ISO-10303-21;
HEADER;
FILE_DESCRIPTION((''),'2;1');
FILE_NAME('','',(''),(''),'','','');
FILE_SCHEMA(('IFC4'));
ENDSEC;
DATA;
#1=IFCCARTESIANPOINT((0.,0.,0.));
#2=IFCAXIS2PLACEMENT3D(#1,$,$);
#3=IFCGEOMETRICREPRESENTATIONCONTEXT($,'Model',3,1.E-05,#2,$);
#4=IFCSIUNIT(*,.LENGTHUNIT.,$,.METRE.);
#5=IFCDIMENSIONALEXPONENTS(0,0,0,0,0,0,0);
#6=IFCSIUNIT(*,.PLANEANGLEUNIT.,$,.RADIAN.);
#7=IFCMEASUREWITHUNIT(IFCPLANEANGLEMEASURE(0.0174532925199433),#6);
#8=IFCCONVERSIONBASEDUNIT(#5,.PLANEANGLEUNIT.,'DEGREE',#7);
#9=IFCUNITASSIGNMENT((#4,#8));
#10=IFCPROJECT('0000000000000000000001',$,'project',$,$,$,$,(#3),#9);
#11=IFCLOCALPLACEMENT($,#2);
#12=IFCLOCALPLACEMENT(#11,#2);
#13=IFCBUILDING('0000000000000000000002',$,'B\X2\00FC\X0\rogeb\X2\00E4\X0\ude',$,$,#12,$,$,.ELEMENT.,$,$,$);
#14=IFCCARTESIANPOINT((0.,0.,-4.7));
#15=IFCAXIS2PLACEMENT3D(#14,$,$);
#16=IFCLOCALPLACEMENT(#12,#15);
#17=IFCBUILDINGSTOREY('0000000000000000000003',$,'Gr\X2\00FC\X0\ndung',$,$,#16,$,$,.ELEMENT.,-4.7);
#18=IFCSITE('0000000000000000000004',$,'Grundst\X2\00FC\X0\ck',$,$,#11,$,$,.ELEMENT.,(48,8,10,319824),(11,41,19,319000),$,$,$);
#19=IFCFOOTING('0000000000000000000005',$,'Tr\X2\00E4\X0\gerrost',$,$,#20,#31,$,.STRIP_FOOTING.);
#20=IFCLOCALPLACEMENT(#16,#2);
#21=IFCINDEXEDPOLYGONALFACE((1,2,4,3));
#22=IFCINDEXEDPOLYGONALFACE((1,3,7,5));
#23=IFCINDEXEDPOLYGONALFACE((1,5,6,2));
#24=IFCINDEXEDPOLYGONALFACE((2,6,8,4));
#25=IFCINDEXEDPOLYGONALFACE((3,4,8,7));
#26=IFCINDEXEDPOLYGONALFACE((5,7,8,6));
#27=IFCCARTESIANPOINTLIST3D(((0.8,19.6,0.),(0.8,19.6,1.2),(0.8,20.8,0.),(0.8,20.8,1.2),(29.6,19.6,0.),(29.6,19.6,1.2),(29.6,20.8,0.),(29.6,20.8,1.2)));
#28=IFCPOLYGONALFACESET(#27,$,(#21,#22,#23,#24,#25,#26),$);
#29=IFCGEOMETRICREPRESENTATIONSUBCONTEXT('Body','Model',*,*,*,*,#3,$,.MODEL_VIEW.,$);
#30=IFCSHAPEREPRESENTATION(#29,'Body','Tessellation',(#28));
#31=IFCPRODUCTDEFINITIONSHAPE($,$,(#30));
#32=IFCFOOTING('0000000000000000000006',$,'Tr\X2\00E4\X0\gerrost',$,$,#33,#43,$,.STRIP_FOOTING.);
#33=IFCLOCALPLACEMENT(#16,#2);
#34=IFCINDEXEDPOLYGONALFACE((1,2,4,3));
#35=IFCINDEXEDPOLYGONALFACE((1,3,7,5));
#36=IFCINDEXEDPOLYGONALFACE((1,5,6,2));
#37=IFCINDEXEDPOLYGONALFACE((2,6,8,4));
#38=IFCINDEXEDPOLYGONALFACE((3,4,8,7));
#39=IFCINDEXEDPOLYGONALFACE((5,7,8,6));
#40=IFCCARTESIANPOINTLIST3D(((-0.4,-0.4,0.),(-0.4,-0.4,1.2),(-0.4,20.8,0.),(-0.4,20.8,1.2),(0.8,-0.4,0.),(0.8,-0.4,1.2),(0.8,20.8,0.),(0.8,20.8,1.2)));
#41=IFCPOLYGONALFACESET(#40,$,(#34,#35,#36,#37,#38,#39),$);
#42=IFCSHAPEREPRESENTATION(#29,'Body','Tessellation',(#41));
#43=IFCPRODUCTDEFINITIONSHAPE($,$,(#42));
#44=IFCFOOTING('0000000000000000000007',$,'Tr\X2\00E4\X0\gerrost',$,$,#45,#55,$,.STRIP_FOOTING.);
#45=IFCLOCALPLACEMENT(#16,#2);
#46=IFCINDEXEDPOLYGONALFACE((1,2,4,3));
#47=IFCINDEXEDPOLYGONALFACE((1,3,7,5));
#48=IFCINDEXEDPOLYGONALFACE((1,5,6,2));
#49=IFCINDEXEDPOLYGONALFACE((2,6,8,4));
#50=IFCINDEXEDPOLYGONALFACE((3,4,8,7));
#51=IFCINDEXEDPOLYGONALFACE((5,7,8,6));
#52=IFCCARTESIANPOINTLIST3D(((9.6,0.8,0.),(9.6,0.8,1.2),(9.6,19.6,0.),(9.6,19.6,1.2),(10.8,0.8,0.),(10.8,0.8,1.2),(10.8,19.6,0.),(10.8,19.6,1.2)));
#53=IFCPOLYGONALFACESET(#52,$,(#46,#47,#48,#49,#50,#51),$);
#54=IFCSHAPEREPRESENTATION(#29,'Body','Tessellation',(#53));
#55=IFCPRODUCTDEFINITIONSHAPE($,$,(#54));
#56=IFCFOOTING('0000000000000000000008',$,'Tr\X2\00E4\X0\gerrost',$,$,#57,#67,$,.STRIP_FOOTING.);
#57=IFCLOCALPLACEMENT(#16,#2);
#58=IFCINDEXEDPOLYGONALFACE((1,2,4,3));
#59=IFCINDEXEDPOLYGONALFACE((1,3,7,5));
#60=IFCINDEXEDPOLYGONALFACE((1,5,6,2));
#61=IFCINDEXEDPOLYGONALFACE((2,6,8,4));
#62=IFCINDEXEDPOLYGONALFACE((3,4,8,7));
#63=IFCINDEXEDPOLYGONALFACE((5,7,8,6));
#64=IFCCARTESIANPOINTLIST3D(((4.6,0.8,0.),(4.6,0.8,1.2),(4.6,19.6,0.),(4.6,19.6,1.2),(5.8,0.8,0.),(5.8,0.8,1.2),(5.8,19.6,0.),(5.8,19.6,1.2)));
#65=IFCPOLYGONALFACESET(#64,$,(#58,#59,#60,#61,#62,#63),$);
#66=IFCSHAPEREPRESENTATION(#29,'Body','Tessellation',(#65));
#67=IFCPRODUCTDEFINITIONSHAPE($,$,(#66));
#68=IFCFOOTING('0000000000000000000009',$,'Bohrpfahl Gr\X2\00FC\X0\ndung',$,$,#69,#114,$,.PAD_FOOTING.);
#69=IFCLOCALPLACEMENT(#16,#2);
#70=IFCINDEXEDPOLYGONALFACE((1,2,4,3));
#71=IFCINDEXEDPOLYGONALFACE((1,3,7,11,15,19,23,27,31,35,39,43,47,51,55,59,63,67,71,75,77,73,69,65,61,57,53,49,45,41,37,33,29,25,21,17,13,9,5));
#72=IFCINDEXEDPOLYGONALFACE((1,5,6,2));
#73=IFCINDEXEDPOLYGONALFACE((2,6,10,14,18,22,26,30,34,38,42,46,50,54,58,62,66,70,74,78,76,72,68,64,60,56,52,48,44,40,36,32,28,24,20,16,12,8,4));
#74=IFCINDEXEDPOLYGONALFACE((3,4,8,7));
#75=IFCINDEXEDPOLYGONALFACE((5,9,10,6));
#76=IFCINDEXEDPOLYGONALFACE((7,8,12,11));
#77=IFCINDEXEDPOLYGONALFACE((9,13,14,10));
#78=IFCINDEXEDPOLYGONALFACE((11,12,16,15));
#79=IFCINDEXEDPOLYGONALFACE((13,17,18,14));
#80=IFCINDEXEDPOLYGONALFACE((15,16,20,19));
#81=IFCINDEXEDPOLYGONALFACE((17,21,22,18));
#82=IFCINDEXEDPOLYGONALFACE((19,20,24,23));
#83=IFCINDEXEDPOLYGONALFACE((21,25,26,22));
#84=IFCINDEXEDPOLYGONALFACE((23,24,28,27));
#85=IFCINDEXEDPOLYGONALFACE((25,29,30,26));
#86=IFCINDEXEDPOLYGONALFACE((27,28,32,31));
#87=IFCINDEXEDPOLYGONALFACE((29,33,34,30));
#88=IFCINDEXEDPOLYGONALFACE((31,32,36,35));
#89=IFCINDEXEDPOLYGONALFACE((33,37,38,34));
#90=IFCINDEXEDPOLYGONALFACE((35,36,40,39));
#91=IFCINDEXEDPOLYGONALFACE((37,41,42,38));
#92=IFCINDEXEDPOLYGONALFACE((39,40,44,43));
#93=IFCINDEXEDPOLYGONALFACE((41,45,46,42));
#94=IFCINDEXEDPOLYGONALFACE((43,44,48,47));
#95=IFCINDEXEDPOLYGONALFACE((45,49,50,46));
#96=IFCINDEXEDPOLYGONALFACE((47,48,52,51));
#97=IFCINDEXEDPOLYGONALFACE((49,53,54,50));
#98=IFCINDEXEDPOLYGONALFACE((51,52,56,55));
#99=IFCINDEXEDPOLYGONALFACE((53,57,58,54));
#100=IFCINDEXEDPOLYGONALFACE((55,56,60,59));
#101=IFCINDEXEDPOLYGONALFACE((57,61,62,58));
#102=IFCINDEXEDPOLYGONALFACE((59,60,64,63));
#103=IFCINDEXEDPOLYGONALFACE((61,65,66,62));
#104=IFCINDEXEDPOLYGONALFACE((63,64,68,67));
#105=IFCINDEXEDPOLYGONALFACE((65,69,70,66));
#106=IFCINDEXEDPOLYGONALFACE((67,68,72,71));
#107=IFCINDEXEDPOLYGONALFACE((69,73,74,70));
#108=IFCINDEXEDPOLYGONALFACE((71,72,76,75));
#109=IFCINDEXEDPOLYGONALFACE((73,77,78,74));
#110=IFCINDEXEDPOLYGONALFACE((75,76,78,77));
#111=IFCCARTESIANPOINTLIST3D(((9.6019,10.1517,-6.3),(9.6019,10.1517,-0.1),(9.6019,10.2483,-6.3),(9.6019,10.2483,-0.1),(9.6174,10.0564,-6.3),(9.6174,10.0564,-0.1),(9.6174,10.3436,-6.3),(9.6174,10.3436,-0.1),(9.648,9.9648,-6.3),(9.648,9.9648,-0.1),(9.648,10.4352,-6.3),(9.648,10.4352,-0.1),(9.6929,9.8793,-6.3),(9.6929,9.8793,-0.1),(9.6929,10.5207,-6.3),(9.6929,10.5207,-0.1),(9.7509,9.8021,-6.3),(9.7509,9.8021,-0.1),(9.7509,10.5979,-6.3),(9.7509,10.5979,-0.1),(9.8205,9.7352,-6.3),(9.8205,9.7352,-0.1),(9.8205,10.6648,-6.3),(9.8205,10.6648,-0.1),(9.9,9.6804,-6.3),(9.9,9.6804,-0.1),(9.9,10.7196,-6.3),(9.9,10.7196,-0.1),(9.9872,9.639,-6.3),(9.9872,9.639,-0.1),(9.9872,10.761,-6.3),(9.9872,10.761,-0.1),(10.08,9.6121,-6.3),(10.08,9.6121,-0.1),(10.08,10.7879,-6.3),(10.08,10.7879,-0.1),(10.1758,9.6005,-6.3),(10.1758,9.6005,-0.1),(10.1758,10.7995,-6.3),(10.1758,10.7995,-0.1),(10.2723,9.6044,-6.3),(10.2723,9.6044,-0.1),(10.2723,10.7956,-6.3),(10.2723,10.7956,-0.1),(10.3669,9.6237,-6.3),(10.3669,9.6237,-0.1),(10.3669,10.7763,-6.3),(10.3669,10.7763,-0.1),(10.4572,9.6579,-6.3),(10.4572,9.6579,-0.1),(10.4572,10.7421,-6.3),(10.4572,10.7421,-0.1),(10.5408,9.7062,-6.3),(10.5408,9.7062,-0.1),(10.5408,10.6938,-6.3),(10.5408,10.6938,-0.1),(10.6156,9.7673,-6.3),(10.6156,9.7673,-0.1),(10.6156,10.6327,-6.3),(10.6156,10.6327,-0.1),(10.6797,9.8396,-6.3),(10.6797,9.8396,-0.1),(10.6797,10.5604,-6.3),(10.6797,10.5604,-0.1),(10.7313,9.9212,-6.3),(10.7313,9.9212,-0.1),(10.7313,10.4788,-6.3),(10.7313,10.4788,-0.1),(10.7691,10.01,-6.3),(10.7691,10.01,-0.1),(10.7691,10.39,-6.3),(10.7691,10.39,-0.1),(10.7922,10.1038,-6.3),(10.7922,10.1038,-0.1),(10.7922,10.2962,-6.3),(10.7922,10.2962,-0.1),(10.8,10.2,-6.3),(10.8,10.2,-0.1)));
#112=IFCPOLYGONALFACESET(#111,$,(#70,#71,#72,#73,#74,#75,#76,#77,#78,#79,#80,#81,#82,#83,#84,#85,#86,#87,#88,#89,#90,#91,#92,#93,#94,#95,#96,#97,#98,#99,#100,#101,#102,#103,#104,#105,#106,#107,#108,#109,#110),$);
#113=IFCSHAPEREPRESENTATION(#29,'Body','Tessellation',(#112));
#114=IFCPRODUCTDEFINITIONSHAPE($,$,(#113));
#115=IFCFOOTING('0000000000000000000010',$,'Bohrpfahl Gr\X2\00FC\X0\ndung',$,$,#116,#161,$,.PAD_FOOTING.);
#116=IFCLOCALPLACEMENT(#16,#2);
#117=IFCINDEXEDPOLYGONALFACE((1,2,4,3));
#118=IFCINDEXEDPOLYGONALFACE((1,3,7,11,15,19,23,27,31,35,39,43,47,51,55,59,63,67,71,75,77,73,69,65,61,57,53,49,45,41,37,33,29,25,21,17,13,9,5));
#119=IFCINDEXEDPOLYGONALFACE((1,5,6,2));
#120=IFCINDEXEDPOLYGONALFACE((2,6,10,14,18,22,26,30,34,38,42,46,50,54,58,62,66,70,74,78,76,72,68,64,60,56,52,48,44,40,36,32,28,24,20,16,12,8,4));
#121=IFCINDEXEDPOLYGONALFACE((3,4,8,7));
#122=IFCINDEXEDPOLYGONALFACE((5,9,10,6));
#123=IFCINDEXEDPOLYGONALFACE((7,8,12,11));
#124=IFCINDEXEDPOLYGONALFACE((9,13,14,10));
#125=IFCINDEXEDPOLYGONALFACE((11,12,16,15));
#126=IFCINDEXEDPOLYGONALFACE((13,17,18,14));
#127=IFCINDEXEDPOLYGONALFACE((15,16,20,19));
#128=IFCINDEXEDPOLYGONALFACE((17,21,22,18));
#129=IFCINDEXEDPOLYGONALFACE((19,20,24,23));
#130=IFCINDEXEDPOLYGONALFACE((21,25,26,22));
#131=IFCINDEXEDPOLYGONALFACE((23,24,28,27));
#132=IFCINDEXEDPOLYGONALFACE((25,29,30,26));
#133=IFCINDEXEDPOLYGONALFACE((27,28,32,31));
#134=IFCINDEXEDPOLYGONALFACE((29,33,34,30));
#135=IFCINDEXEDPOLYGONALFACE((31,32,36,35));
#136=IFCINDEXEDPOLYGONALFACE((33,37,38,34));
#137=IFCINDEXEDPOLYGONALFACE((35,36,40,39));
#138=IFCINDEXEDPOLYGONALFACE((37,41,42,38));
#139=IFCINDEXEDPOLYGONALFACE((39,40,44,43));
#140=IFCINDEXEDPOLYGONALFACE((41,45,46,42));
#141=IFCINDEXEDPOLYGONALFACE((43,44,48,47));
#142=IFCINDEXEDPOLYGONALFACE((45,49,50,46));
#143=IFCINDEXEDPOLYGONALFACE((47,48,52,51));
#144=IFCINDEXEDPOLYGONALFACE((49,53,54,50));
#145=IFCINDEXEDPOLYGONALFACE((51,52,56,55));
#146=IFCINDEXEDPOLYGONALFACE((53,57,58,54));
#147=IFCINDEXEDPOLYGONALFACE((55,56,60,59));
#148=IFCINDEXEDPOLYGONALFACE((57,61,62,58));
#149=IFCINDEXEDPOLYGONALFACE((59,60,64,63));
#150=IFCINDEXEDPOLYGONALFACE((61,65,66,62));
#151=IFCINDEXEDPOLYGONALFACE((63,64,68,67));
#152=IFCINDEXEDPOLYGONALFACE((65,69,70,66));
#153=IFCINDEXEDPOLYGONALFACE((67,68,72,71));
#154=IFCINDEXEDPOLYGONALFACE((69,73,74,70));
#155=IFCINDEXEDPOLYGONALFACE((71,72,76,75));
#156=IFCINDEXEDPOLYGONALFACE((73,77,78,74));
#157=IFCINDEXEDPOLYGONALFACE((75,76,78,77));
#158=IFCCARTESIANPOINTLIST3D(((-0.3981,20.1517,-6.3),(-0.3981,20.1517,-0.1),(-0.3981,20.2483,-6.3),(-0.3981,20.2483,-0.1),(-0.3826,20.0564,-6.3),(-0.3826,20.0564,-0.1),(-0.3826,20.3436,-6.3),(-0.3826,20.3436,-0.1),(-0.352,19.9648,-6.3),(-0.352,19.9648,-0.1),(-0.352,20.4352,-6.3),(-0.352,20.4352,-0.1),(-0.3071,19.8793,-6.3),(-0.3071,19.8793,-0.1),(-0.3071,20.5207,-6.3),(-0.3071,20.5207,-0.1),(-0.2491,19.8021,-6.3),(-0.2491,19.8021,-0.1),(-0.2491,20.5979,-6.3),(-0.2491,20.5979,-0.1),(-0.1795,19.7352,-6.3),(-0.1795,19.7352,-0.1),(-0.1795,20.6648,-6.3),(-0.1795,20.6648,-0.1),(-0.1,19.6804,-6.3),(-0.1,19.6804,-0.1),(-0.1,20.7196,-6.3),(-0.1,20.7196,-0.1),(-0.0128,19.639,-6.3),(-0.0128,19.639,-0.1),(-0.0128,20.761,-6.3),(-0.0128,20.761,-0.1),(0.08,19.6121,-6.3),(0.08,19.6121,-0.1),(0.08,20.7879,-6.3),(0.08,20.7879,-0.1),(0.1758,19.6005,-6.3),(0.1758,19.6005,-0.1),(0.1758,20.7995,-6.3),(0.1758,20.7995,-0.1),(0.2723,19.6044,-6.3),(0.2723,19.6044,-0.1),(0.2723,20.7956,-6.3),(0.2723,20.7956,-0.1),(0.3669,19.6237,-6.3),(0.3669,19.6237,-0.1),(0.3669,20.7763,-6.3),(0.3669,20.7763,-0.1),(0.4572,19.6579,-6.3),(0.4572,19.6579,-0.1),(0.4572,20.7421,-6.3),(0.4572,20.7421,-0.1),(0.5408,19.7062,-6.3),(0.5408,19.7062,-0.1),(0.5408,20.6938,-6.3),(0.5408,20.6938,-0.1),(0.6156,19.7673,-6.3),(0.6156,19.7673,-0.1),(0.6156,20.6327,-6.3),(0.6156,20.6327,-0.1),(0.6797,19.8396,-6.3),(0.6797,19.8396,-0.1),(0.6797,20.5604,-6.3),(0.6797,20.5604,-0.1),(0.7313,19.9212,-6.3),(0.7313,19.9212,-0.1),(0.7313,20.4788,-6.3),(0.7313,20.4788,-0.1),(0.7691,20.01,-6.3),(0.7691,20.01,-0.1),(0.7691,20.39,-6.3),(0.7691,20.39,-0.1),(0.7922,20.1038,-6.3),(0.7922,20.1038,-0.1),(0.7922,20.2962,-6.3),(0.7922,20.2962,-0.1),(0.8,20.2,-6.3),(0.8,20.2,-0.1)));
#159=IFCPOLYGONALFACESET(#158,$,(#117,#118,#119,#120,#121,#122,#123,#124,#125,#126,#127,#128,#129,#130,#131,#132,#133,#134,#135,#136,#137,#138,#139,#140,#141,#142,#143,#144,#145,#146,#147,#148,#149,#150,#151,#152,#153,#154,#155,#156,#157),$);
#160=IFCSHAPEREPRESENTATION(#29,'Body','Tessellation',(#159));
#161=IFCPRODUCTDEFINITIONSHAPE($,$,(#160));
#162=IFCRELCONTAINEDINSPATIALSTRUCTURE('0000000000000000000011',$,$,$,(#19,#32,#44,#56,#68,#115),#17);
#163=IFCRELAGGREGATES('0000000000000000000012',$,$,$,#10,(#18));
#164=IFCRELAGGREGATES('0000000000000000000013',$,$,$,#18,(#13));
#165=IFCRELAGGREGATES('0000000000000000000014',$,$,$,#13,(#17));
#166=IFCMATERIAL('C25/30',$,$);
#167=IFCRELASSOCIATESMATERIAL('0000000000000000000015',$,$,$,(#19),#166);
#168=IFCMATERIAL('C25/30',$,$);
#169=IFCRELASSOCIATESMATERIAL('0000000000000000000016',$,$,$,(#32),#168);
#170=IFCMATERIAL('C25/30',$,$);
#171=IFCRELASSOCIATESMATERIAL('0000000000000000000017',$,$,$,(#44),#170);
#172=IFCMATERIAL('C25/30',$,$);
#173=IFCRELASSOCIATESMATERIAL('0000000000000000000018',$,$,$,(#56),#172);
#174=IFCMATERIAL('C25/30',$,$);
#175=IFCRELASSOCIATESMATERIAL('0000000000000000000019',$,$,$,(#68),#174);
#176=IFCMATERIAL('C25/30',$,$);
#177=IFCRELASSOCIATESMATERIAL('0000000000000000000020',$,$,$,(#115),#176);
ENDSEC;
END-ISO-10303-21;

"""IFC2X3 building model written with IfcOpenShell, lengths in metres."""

from ifc_helpers import new_model, entity, si_unit, converted_unit, frame, frame_2d, origin, place, context, subcontext, project, spatial, rectangle, circle, extrude, material, element, save


model = new_model("IFC2X3")

# Units and contexts
model_context = context("Model", 3, precision=1e-05, world=origin())
body_context = subcontext(model_context, "Body", "Model", "MODEL_VIEW")
ifc_project = project(units=[si_unit("LENGTHUNIT", "METRE"), converted_unit("PLANEANGLEUNIT", "DEGREE", entity("IfcPlaneAngleMeasure", 0.0174532925199433), si_unit("PLANEANGLEUNIT", "RADIAN"), dimensions=[0, 0, 0, 0, 0, 0, 0])], contexts=[model_context])

# Site, building, storey
site_placement = place(None, origin())
site = spatial("IfcSite", under=ifc_project, at=site_placement, Name="Grundstück", CompositionType="ELEMENT", RefLatitude=(48, 8, 10, 319824), RefLongitude=(11, 41, 19, 319000))
building_placement = place(site_placement, origin())
building = spatial("IfcBuilding", under=site, at=building_placement, Name="Bürogebäude", CompositionType="ELEMENT")
storey_placement = place(building_placement, frame((0.0, 0.0, -4.7)))
storey = spatial("IfcBuildingStorey", under=building, at=storey_placement, Name="Gründung", CompositionType="ELEMENT", Elevation=-4.7)

# Footings
ifc_material_1 = material(Name="C25/30")
footing_1_placement = place(storey_placement, frame((0.8, 19.6, 0.0)))
element("IfcFooting", 1, at=footing_1_placement, inside=storey, material=ifc_material_1, Name="Trägerrost", PredefinedType="STRIP_FOOTING", context=body_context, shape_type="SweptSolid", body=[
    extrude(rectangle(XDim=1.2, YDim=1.2, at=frame_2d((0.6, 0.6), x_axis=(1.0, 0.0))), frame((0.0, 0.0, 0.0), z_axis=(1.0, 0.0, 0.0), x_axis=(0.0, 1.0, 0.0)), (0.0, 0.0, 1.0), 28.8),
])
ifc_material_2 = material(Name="C25/30")
footing_2_placement = place(storey_placement, frame((0.8, -0.4, 0.0), z_axis=(0.0, 0.0, 1.0), x_axis=(0.0, 1.0, 0.0)))
element("IfcFooting", 2, at=footing_2_placement, inside=storey, material=ifc_material_2, Name="Trägerrost", PredefinedType="STRIP_FOOTING", context=body_context, shape_type="SweptSolid", body=[
    extrude(rectangle(XDim=1.2, YDim=1.2, at=frame_2d((0.6, 0.6), x_axis=(1.0, 0.0))), frame((0.0, 0.0, 0.0), z_axis=(1.0, 0.0, 0.0), x_axis=(0.0, 1.0, 0.0)), (0.0, 0.0, 1.0), 21.2),
])
ifc_material_3 = material(Name="C25/30")
footing_3_placement = place(storey_placement, frame((10.8, 0.8, 0.0), z_axis=(0.0, 0.0, 1.0), x_axis=(0.0, 1.0, 0.0)))
element("IfcFooting", 3, at=footing_3_placement, inside=storey, material=ifc_material_3, Name="Trägerrost", PredefinedType="STRIP_FOOTING", context=body_context, shape_type="SweptSolid", body=[
    extrude(rectangle(XDim=1.2, YDim=1.2, at=frame_2d((0.6, 0.6), x_axis=(1.0, 0.0))), frame((0.0, 0.0, 0.0), z_axis=(1.0, 0.0, 0.0), x_axis=(0.0, 1.0, 0.0)), (0.0, 0.0, 1.0), 18.8),
])
ifc_material_4 = material(Name="C25/30")
footing_4_placement = place(storey_placement, frame((5.8, 0.8, 0.0), z_axis=(0.0, 0.0, 1.0), x_axis=(0.0, 1.0, 0.0)))
element("IfcFooting", 4, at=footing_4_placement, inside=storey, material=ifc_material_4, Name="Trägerrost", PredefinedType="STRIP_FOOTING", context=body_context, shape_type="SweptSolid", body=[
    extrude(rectangle(XDim=1.2, YDim=1.2, at=frame_2d((0.6, 0.6), x_axis=(1.0, 0.0))), frame((0.0, 0.0, 0.0), z_axis=(1.0, 0.0, 0.0), x_axis=(0.0, 1.0, 0.0)), (0.0, 0.0, 1.0), 18.8),
])
ifc_material_5 = material(Name="C25/30")
footing_5_placement = place(storey_placement, frame((9.6025, 9.6025, -6.3)))
element("IfcFooting", 5, at=footing_5_placement, inside=storey, material=ifc_material_5, Name="Bohrpfahl Gründung", PredefinedType="PAD_FOOTING", context=body_context, shape_type="SweptSolid", body=[
    extrude(circle(Radius=0.6, at=frame_2d((0.6, 0.6), x_axis=(1.0, 0.0))), frame((-0.0025, -0.0025, 0.0), z_axis=(0.0, 0.0, 1.0), x_axis=(1.0, 0.0, 0.0)), (0.0, 0.0, 1.0), 6.2),
])
ifc_material_6 = material(Name="C25/30")
footing_6_placement = place(storey_placement, frame((-0.3975, 19.6025, -6.3)))
element("IfcFooting", 6, at=footing_6_placement, inside=storey, material=ifc_material_6, Name="Bohrpfahl Gründung", PredefinedType="PAD_FOOTING", context=body_context, shape_type="SweptSolid", body=[
    extrude(circle(Radius=0.6, at=frame_2d((0.6, 0.6), x_axis=(1.0, 0.0))), frame((-0.0025, -0.0025, 0.0), z_axis=(0.0, 0.0, 1.0), x_axis=(1.0, 0.0, 0.0)), (0.0, 0.0, 1.0), 6.2),
])

save(model, "model.ifc")
